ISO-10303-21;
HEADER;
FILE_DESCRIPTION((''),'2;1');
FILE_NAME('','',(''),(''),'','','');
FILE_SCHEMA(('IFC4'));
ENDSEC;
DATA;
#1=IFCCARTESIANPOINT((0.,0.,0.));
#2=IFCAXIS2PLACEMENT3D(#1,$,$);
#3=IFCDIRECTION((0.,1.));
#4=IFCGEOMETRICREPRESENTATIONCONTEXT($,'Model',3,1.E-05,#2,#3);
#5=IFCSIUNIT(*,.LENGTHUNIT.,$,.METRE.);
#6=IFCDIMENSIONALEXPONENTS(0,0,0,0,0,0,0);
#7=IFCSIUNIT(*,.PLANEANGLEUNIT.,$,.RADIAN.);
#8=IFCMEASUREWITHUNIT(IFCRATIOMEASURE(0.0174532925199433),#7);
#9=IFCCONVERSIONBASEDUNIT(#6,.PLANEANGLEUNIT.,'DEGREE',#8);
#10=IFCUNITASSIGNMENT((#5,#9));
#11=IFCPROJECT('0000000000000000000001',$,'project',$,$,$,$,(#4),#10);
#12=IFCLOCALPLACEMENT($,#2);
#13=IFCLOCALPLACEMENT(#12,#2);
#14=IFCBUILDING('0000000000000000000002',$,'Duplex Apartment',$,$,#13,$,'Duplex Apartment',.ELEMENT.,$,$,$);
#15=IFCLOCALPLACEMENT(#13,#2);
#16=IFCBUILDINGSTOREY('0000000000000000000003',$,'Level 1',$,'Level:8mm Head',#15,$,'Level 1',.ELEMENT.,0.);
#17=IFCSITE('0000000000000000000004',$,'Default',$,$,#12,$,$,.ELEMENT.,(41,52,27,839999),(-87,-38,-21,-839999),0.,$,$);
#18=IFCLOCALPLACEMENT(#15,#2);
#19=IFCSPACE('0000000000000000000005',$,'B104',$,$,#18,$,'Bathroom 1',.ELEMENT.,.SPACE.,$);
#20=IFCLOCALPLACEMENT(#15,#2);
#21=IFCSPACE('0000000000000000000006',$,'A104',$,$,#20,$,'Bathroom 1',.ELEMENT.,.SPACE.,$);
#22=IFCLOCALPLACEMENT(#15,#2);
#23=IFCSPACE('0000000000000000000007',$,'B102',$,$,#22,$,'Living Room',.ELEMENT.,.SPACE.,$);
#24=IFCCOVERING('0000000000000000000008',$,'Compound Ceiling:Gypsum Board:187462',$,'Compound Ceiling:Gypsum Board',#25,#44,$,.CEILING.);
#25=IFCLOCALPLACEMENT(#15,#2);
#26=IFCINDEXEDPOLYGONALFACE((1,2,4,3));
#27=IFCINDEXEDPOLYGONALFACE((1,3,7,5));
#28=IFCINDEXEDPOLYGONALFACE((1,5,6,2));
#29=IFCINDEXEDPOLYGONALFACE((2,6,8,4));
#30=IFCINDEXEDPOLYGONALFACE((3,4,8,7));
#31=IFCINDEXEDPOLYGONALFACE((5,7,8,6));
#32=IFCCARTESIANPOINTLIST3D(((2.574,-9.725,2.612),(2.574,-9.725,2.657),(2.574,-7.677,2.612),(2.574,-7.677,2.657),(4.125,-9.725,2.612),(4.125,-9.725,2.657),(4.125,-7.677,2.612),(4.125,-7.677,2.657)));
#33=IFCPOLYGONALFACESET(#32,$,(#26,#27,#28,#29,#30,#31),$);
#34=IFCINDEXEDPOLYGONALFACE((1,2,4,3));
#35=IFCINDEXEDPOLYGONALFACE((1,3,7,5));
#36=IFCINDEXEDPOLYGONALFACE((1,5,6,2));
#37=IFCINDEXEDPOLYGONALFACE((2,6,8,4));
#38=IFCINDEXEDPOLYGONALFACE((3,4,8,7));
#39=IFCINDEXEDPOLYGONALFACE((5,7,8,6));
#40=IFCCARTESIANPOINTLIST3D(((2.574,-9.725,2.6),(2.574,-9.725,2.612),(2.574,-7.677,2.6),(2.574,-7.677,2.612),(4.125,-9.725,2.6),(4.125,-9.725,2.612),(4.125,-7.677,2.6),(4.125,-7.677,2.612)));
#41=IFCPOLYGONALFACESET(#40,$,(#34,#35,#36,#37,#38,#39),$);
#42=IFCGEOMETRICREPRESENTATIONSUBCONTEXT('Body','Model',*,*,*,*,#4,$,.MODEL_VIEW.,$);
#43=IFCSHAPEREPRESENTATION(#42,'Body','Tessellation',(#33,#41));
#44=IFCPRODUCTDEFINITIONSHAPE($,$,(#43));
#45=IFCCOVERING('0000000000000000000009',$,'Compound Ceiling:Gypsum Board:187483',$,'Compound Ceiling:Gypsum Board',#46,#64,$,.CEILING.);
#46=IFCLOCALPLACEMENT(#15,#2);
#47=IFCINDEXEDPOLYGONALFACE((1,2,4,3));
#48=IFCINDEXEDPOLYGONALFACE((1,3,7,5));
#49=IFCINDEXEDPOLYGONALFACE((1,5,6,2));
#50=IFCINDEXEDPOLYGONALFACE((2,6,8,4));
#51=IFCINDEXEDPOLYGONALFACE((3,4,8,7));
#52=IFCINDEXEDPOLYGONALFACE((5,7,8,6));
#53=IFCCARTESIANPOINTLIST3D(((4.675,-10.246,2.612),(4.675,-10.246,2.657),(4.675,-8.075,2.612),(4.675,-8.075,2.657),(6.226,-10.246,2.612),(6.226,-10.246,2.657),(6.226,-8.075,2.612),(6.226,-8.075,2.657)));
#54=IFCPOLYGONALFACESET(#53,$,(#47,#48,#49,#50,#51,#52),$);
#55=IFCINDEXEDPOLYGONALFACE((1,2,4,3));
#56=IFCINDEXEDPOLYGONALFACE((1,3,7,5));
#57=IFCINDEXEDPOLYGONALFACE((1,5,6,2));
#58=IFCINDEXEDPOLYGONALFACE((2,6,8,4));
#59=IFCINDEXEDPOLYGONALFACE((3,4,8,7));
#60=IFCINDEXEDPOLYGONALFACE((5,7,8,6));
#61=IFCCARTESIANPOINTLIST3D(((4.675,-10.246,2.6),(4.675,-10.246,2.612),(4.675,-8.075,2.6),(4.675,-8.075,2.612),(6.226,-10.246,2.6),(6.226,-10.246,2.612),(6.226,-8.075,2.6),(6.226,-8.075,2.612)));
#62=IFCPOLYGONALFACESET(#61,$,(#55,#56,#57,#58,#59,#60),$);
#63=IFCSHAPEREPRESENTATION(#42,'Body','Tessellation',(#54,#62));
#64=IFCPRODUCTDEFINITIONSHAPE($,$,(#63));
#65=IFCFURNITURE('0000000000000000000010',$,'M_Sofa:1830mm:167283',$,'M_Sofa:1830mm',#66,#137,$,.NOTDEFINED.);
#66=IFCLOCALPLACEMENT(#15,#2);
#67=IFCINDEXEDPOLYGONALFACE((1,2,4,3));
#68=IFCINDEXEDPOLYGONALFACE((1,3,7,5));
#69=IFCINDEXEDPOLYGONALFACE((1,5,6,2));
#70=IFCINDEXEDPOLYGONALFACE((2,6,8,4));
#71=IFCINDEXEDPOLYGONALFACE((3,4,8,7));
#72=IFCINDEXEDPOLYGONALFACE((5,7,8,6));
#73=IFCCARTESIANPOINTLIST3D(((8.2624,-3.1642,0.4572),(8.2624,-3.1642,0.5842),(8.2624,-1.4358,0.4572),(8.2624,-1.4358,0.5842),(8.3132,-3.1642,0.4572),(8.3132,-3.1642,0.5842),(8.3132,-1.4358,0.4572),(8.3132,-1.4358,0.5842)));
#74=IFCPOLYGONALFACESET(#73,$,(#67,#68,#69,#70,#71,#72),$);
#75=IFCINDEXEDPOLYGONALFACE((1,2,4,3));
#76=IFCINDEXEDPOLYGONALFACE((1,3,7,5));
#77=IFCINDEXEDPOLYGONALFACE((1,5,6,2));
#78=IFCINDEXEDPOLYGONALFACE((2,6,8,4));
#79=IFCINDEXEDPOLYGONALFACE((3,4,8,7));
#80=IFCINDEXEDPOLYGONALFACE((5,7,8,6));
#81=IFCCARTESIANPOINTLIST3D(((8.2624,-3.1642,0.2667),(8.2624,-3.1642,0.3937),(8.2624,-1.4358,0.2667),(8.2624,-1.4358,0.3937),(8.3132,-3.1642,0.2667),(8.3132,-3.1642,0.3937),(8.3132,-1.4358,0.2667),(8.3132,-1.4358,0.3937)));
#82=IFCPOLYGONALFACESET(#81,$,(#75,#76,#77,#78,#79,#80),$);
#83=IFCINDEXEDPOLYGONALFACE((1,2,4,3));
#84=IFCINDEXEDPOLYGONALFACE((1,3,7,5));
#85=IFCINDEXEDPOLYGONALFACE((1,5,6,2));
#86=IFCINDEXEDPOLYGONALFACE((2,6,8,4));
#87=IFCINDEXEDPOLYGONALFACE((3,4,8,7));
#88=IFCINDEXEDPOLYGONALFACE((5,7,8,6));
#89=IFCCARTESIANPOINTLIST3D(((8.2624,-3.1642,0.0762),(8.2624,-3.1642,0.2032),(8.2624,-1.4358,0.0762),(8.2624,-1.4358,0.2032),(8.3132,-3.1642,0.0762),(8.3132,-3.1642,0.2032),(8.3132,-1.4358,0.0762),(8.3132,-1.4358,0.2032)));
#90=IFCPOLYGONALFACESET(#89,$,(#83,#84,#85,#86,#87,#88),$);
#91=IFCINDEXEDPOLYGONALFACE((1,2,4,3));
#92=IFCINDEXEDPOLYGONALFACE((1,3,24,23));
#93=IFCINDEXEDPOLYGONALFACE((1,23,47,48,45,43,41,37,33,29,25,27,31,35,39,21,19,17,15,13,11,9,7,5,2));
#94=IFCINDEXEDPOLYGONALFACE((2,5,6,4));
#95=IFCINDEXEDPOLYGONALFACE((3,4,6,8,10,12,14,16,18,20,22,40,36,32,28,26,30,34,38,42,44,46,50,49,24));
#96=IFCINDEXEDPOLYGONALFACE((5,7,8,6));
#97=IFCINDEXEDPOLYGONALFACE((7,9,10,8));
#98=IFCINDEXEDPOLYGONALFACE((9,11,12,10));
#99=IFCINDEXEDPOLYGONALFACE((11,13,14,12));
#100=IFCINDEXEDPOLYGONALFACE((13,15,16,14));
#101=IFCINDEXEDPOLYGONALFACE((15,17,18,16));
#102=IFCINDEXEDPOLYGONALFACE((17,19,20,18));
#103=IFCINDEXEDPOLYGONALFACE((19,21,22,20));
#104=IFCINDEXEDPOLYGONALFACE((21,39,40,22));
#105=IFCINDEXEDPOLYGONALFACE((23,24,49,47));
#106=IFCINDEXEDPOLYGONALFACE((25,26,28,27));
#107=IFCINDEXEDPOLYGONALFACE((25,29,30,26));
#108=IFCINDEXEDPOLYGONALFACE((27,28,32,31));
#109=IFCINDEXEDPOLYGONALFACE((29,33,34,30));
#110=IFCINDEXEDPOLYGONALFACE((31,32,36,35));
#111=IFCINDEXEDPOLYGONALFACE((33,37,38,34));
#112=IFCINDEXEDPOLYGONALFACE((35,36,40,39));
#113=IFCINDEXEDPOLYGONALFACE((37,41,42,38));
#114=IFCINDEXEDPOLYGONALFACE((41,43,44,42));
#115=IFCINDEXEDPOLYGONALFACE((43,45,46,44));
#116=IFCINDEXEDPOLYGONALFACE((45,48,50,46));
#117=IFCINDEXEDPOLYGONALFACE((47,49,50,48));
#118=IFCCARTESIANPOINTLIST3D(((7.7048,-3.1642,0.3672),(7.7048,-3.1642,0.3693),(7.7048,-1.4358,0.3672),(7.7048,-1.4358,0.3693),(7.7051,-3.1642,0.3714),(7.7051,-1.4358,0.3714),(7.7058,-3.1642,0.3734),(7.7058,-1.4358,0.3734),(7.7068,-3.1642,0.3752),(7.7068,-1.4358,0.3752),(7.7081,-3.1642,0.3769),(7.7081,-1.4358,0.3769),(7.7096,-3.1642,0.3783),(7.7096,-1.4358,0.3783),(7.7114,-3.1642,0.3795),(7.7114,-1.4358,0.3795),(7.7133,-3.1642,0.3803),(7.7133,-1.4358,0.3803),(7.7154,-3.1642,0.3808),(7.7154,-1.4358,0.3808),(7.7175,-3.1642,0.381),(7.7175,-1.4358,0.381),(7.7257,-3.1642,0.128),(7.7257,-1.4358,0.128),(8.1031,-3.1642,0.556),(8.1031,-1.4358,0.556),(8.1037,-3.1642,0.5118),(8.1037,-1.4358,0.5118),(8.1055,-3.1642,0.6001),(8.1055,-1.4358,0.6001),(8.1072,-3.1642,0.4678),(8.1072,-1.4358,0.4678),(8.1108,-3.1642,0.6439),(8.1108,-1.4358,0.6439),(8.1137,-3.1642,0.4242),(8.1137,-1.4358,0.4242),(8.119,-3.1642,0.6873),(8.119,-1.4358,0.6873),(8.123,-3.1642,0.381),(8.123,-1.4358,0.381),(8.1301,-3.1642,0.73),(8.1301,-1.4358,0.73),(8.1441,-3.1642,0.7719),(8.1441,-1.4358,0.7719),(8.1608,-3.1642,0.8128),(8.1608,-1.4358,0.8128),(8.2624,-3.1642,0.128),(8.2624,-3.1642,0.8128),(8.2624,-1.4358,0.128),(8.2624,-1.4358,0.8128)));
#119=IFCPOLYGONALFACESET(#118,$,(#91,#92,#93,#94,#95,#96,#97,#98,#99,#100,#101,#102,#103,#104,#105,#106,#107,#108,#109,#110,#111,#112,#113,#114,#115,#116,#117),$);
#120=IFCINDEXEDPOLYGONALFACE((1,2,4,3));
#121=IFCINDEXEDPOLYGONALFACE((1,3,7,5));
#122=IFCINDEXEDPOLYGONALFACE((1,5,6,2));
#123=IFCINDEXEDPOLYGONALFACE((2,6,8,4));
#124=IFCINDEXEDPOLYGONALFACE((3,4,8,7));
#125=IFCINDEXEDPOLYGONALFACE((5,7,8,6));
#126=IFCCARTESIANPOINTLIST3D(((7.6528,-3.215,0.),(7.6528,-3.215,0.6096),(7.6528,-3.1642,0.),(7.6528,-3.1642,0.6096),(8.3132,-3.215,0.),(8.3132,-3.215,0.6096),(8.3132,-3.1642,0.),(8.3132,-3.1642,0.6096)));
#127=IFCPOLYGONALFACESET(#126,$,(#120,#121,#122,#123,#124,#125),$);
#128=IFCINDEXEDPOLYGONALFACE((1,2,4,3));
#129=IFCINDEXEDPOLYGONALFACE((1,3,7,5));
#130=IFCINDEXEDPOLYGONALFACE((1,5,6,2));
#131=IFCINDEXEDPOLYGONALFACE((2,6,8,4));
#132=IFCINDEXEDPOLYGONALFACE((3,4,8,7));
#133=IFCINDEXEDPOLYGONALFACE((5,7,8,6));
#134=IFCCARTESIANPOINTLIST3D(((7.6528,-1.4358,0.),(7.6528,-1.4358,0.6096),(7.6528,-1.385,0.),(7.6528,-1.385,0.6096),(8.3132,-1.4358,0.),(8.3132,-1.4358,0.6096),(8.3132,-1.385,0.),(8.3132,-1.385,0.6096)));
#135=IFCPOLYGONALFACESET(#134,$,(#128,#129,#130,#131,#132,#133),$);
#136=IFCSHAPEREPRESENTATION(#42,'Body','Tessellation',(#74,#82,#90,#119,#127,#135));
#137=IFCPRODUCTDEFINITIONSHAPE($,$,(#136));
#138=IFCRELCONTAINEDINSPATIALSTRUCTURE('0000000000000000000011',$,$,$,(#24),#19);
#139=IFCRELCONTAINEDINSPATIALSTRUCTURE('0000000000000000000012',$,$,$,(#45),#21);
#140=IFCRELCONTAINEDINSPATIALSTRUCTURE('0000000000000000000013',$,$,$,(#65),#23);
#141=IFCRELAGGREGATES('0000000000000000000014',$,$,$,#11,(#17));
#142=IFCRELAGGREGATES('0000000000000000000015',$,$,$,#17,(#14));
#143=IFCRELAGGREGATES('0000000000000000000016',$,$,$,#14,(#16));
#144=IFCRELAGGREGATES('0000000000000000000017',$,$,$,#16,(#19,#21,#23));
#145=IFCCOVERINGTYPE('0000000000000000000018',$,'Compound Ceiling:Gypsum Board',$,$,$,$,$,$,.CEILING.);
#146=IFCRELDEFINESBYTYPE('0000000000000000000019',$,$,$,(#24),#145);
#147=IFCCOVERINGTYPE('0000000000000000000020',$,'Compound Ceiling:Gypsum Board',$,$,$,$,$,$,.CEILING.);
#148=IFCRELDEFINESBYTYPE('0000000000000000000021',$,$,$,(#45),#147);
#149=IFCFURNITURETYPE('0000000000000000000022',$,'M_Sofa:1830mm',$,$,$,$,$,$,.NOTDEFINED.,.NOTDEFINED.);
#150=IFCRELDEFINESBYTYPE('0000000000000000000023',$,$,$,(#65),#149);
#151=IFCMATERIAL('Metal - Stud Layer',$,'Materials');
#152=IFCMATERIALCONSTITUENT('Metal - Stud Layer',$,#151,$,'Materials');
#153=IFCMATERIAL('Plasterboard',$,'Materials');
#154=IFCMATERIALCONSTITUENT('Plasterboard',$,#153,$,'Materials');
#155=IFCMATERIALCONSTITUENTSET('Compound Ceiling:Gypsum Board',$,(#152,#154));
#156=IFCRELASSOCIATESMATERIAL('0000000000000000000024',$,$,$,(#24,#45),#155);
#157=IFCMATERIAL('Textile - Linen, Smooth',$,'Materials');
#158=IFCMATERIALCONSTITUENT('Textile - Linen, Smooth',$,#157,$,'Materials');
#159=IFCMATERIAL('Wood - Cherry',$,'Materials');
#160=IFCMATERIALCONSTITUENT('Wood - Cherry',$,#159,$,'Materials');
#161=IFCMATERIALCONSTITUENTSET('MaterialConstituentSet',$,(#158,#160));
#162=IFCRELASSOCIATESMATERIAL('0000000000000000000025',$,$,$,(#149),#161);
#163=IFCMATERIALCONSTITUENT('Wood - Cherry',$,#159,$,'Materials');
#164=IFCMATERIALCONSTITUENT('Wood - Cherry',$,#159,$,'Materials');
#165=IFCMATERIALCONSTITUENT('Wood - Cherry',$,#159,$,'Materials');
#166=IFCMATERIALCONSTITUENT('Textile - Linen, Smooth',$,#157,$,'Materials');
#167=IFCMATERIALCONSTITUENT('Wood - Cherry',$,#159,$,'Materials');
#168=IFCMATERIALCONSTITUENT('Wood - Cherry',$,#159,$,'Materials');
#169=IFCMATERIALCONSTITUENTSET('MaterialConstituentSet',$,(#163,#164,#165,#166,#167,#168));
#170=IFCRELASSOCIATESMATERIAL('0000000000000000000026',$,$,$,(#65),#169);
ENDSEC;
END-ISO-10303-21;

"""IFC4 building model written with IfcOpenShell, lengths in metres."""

from ifc_helpers import new_model, entity, si_unit, converted_unit, direction, frame, origin, place, context, subcontext, project, spatial, indexed_curve, outline, extrude, source, transform, mapped, material, constituent, constituent_set, type_object, type_shapes, element, save


model = new_model("IFC4")

# Units and contexts
model_context = context("Model", 3, precision=1e-05, world=origin(), true_north=direction((0.0, 1.0)))
body_context = subcontext(model_context, "Body", "Model", "MODEL_VIEW")
ifc_project = project(units=[si_unit("LENGTHUNIT", "METRE"), converted_unit("PLANEANGLEUNIT", "DEGREE", entity("IfcRatioMeasure", 0.0174532925199433), si_unit("PLANEANGLEUNIT", "RADIAN"), dimensions=[0, 0, 0, 0, 0, 0, 0])], contexts=[model_context])

# Site, building, storey
site_placement = place(None, origin())
site = spatial("IfcSite", under=ifc_project, at=site_placement, Name="Default", CompositionType="ELEMENT", RefLatitude=(41, 52, 27, 839999), RefLongitude=(-87, -38, -21, -839999), RefElevation=0.0)
building_placement = place(site_placement, origin())
building = spatial("IfcBuilding", under=site, at=building_placement, Name="Duplex Apartment", LongName="Duplex Apartment", CompositionType="ELEMENT")
storey_placement = place(building_placement, origin())
storey = spatial("IfcBuildingStorey", under=building, at=storey_placement, Name="Level 1", ObjectType="Level:8mm Head", LongName="Level 1", CompositionType="ELEMENT", Elevation=0.0)

# Shared definitions
ifc_material_1 = material(Name="Metal - Stud Layer", Category="Materials")
ifc_material_2 = material(Name="Plasterboard", Category="Materials")

# Shared definitions
ifc_constituent_1 = constituent(ifc_material_1, Name="Metal - Stud Layer", Category="Materials")
ifc_constituent_2 = constituent(ifc_material_2, Name="Plasterboard", Category="Materials")
ifc_constituent_set_1 = constituent_set(constituents=[ifc_constituent_1, ifc_constituent_2], Name="Compound Ceiling:Gypsum Board")

# Shared definitions
space_1_placement = place(storey_placement, origin())
space_1 = spatial("IfcSpace", under=storey, at=space_1_placement, Name="B104", LongName="Bathroom 1", CompositionType="ELEMENT", PredefinedType="SPACE")

# Covering
covering_type_1 = type_object("IfcCoveringType", Name="Compound Ceiling:Gypsum Board", PredefinedType="CEILING")
covering_1_placement = place(space_1_placement, origin())
element("IfcCovering", 1, at=covering_1_placement, inside=space_1, type_object=covering_type_1, material=ifc_constituent_set_1, Name="Compound Ceiling:Gypsum Board:187462", ObjectType="Compound Ceiling:Gypsum Board", PredefinedType="CEILING", context=body_context, shape_type="SweptSolid", body=[
    extrude(outline(indexed_curve([(-1.024, -0.7755), (1.024, -0.7755), (1.024, 0.7755), (-1.024, 0.7755), (-1.024, -0.7755)], self_intersect=False)), frame((3.3495, -8.701, 2.612), z_axis=(0.0, 0.0, 1.0), x_axis=(0.0, 1.0, 0.0)), (0.0, 0.0, 1.0), 0.045),
    extrude(outline(indexed_curve([(-0.7755, -1.024), (0.7755, -1.024), (0.7755, 1.024), (-0.7755, 1.024), (-0.7755, -1.024)], self_intersect=False)), frame((3.3495, -8.701, 2.6)), (0.0, 0.0, 1.0), 0.012),
])

# Shared definitions
space_2_placement = place(storey_placement, origin())
space_2 = spatial("IfcSpace", under=storey, at=space_2_placement, Name="A104", LongName="Bathroom 1", CompositionType="ELEMENT", PredefinedType="SPACE")

# Covering
covering_type_2 = type_object("IfcCoveringType", Name="Compound Ceiling:Gypsum Board", PredefinedType="CEILING")
covering_2_placement = place(space_2_placement, origin())
element("IfcCovering", 2, at=covering_2_placement, inside=space_2, type_object=covering_type_2, material=ifc_constituent_set_1, Name="Compound Ceiling:Gypsum Board:187483", ObjectType="Compound Ceiling:Gypsum Board", PredefinedType="CEILING", context=body_context, shape_type="SweptSolid", body=[
    extrude(outline(indexed_curve([(-0.7755, -1.0855), (0.7755, -1.0855), (0.7755, 1.0855), (-0.7755, 1.0855), (-0.7755, -1.0855)], self_intersect=False)), frame((5.4505, -9.1605, 2.612)), (0.0, 0.0, 1.0), 0.045),
    extrude(outline(indexed_curve([(-1.0855, -0.7755), (1.0855, -0.7755), (1.0855, 0.7755), (-1.0855, 0.7755), (-1.0855, -0.7755)], self_intersect=False)), frame((5.4505, -9.1605, 2.6), z_axis=(0.0, 0.0, 1.0), x_axis=(0.0, -1.0, 0.0)), (0.0, 0.0, 1.0), 0.012),
])

# Shared definitions
space_3_placement = place(storey_placement, origin())
space_3 = spatial("IfcSpace", under=storey, at=space_3_placement, Name="B102", LongName="Living Room", CompositionType="ELEMENT", PredefinedType="SPACE")

# Furniture
ifc_material_3 = material(Name="Wood - Cherry", Category="Materials")
ifc_constituent_3 = constituent(ifc_material_3, Name="Wood - Cherry", Category="Materials")
ifc_constituent_4 = constituent(ifc_material_3, Name="Wood - Cherry", Category="Materials")
ifc_constituent_5 = constituent(ifc_material_3, Name="Wood - Cherry", Category="Materials")
ifc_material_4 = material(Name="Textile - Linen, Smooth", Category="Materials")
ifc_constituent_6 = constituent(ifc_material_4, Name="Textile - Linen, Smooth", Category="Materials")
ifc_constituent_7 = constituent(ifc_material_3, Name="Wood - Cherry", Category="Materials")
ifc_constituent_8 = constituent(ifc_material_3, Name="Wood - Cherry", Category="Materials")
ifc_constituent_set_2 = constituent_set(constituents=[ifc_constituent_3, ifc_constituent_4, ifc_constituent_5, ifc_constituent_6, ifc_constituent_7, ifc_constituent_8], Name="MaterialConstituentSet")
ifc_constituent_9 = constituent(ifc_material_4, Name="Textile - Linen, Smooth", Category="Materials")
ifc_constituent_10 = constituent(ifc_material_3, Name="Wood - Cherry", Category="Materials")
ifc_constituent_set_3 = constituent_set(constituents=[ifc_constituent_9, ifc_constituent_10], Name="MaterialConstituentSet")
furniture_type_1 = type_object("IfcFurnitureType", Name="M_Sofa:1830mm", AssemblyPlace="NOTDEFINED", PredefinedType="NOTDEFINED", material=ifc_constituent_set_3)
shared_shape_1 = source(origin(), body_context, "Body", "SweptSolid", [
    extrude(outline(indexed_curve([(-0.8642, -0.0254), (0.8642, -0.0254), (0.8642, 0.0254), (-0.8642, 0.0254), (-0.8642, -0.0254)], self_intersect=False)), frame((0.0704, 0.451, 0.4572)), (0.0, 0.0, 1.0), 0.127),
    extrude(outline(indexed_curve([(-0.8642, -0.0254), (0.8642, -0.0254), (0.8642, 0.0254), (-0.8642, 0.0254), (-0.8642, -0.0254)], self_intersect=False)), frame((0.0704, 0.451, 0.2667)), (0.0, 0.0, 1.0), 0.127),
    extrude(outline(indexed_curve([(-0.8642, -0.0254), (0.8642, -0.0254), (0.8642, 0.0254), (-0.8642, 0.0254), (-0.8642, -0.0254)], self_intersect=False)), frame((0.0704, 0.451, 0.0762)), (0.0, 0.0, 1.0), 0.127),
    extrude(outline(indexed_curve([(-0.1292, 0.0491), (0.2763, 0.0491), (0.2784, 0.0493), (0.2805, 0.0498), (0.2824, 0.0506), (0.2842, 0.0518), (0.2857, 0.0532), (0.287, 0.0549), (0.288, 0.0567), (0.2887, 0.0587), (0.289, 0.0608), (0.289, 0.0629), (0.2681, 0.3021), (-0.2686, 0.3021), (-0.2686, -0.3827), (-0.167, -0.3827), (-0.1503, -0.3418), (-0.1363, -0.2999), (-0.1252, -0.2572), (-0.117, -0.2138), (-0.1117, -0.17), (-0.1093, -0.1259), (-0.1099, -0.0817), (-0.1134, -0.0377), (-0.1199, 0.006), (-0.1292, 0.0491)], self_intersect=False)), frame((-0.7938, 0.157, 0.4301), z_axis=(1.0, 0.0, 0.0), x_axis=(0.0, -1.0, 0.0)), (0.0, 0.0, 1.0), 1.7284),
    extrude(outline(indexed_curve([(-0.0254, -0.3302), (0.0254, -0.3302), (0.0254, 0.3302), (-0.0254, 0.3302), (-0.0254, -0.3302)], self_intersect=False)), frame((0.96, 0.1462, 0.0), z_axis=(0.0, 0.0, 1.0), x_axis=(-1.0, 0.0, 0.0)), (0.0, 0.0, 1.0), 0.6096),
    extrude(outline(indexed_curve([(-0.0254, -0.3302), (0.0254, -0.3302), (0.0254, 0.3302), (-0.0254, 0.3302), (-0.0254, -0.3302)], self_intersect=False)), frame((-0.8192, 0.1462, 0.0), z_axis=(0.0, 0.0, 1.0), x_axis=(-1.0, 0.0, 0.0)), (0.0, 0.0, 1.0), 0.6096),
])
type_shapes(furniture_type_1, [shared_shape_1])
furniture_1_placement = place(space_3_placement, frame((7.8368, -2.2296, 0.0), z_axis=(0.0, 0.0, 1.0), x_axis=(0.0, -1.0, 0.0)))
element("IfcFurniture", 3, at=furniture_1_placement, inside=space_3, type_object=furniture_type_1, material=ifc_constituent_set_2, Name="M_Sofa:1830mm:167283", ObjectType="M_Sofa:1830mm", PredefinedType="NOTDEFINED", context=body_context, shape_type="MappedRepresentation", body=[
    mapped(shared_shape_1, transform((0.0, 0.0, 0.0), scale=1.0)),
])

save(model, "model.ifc")
